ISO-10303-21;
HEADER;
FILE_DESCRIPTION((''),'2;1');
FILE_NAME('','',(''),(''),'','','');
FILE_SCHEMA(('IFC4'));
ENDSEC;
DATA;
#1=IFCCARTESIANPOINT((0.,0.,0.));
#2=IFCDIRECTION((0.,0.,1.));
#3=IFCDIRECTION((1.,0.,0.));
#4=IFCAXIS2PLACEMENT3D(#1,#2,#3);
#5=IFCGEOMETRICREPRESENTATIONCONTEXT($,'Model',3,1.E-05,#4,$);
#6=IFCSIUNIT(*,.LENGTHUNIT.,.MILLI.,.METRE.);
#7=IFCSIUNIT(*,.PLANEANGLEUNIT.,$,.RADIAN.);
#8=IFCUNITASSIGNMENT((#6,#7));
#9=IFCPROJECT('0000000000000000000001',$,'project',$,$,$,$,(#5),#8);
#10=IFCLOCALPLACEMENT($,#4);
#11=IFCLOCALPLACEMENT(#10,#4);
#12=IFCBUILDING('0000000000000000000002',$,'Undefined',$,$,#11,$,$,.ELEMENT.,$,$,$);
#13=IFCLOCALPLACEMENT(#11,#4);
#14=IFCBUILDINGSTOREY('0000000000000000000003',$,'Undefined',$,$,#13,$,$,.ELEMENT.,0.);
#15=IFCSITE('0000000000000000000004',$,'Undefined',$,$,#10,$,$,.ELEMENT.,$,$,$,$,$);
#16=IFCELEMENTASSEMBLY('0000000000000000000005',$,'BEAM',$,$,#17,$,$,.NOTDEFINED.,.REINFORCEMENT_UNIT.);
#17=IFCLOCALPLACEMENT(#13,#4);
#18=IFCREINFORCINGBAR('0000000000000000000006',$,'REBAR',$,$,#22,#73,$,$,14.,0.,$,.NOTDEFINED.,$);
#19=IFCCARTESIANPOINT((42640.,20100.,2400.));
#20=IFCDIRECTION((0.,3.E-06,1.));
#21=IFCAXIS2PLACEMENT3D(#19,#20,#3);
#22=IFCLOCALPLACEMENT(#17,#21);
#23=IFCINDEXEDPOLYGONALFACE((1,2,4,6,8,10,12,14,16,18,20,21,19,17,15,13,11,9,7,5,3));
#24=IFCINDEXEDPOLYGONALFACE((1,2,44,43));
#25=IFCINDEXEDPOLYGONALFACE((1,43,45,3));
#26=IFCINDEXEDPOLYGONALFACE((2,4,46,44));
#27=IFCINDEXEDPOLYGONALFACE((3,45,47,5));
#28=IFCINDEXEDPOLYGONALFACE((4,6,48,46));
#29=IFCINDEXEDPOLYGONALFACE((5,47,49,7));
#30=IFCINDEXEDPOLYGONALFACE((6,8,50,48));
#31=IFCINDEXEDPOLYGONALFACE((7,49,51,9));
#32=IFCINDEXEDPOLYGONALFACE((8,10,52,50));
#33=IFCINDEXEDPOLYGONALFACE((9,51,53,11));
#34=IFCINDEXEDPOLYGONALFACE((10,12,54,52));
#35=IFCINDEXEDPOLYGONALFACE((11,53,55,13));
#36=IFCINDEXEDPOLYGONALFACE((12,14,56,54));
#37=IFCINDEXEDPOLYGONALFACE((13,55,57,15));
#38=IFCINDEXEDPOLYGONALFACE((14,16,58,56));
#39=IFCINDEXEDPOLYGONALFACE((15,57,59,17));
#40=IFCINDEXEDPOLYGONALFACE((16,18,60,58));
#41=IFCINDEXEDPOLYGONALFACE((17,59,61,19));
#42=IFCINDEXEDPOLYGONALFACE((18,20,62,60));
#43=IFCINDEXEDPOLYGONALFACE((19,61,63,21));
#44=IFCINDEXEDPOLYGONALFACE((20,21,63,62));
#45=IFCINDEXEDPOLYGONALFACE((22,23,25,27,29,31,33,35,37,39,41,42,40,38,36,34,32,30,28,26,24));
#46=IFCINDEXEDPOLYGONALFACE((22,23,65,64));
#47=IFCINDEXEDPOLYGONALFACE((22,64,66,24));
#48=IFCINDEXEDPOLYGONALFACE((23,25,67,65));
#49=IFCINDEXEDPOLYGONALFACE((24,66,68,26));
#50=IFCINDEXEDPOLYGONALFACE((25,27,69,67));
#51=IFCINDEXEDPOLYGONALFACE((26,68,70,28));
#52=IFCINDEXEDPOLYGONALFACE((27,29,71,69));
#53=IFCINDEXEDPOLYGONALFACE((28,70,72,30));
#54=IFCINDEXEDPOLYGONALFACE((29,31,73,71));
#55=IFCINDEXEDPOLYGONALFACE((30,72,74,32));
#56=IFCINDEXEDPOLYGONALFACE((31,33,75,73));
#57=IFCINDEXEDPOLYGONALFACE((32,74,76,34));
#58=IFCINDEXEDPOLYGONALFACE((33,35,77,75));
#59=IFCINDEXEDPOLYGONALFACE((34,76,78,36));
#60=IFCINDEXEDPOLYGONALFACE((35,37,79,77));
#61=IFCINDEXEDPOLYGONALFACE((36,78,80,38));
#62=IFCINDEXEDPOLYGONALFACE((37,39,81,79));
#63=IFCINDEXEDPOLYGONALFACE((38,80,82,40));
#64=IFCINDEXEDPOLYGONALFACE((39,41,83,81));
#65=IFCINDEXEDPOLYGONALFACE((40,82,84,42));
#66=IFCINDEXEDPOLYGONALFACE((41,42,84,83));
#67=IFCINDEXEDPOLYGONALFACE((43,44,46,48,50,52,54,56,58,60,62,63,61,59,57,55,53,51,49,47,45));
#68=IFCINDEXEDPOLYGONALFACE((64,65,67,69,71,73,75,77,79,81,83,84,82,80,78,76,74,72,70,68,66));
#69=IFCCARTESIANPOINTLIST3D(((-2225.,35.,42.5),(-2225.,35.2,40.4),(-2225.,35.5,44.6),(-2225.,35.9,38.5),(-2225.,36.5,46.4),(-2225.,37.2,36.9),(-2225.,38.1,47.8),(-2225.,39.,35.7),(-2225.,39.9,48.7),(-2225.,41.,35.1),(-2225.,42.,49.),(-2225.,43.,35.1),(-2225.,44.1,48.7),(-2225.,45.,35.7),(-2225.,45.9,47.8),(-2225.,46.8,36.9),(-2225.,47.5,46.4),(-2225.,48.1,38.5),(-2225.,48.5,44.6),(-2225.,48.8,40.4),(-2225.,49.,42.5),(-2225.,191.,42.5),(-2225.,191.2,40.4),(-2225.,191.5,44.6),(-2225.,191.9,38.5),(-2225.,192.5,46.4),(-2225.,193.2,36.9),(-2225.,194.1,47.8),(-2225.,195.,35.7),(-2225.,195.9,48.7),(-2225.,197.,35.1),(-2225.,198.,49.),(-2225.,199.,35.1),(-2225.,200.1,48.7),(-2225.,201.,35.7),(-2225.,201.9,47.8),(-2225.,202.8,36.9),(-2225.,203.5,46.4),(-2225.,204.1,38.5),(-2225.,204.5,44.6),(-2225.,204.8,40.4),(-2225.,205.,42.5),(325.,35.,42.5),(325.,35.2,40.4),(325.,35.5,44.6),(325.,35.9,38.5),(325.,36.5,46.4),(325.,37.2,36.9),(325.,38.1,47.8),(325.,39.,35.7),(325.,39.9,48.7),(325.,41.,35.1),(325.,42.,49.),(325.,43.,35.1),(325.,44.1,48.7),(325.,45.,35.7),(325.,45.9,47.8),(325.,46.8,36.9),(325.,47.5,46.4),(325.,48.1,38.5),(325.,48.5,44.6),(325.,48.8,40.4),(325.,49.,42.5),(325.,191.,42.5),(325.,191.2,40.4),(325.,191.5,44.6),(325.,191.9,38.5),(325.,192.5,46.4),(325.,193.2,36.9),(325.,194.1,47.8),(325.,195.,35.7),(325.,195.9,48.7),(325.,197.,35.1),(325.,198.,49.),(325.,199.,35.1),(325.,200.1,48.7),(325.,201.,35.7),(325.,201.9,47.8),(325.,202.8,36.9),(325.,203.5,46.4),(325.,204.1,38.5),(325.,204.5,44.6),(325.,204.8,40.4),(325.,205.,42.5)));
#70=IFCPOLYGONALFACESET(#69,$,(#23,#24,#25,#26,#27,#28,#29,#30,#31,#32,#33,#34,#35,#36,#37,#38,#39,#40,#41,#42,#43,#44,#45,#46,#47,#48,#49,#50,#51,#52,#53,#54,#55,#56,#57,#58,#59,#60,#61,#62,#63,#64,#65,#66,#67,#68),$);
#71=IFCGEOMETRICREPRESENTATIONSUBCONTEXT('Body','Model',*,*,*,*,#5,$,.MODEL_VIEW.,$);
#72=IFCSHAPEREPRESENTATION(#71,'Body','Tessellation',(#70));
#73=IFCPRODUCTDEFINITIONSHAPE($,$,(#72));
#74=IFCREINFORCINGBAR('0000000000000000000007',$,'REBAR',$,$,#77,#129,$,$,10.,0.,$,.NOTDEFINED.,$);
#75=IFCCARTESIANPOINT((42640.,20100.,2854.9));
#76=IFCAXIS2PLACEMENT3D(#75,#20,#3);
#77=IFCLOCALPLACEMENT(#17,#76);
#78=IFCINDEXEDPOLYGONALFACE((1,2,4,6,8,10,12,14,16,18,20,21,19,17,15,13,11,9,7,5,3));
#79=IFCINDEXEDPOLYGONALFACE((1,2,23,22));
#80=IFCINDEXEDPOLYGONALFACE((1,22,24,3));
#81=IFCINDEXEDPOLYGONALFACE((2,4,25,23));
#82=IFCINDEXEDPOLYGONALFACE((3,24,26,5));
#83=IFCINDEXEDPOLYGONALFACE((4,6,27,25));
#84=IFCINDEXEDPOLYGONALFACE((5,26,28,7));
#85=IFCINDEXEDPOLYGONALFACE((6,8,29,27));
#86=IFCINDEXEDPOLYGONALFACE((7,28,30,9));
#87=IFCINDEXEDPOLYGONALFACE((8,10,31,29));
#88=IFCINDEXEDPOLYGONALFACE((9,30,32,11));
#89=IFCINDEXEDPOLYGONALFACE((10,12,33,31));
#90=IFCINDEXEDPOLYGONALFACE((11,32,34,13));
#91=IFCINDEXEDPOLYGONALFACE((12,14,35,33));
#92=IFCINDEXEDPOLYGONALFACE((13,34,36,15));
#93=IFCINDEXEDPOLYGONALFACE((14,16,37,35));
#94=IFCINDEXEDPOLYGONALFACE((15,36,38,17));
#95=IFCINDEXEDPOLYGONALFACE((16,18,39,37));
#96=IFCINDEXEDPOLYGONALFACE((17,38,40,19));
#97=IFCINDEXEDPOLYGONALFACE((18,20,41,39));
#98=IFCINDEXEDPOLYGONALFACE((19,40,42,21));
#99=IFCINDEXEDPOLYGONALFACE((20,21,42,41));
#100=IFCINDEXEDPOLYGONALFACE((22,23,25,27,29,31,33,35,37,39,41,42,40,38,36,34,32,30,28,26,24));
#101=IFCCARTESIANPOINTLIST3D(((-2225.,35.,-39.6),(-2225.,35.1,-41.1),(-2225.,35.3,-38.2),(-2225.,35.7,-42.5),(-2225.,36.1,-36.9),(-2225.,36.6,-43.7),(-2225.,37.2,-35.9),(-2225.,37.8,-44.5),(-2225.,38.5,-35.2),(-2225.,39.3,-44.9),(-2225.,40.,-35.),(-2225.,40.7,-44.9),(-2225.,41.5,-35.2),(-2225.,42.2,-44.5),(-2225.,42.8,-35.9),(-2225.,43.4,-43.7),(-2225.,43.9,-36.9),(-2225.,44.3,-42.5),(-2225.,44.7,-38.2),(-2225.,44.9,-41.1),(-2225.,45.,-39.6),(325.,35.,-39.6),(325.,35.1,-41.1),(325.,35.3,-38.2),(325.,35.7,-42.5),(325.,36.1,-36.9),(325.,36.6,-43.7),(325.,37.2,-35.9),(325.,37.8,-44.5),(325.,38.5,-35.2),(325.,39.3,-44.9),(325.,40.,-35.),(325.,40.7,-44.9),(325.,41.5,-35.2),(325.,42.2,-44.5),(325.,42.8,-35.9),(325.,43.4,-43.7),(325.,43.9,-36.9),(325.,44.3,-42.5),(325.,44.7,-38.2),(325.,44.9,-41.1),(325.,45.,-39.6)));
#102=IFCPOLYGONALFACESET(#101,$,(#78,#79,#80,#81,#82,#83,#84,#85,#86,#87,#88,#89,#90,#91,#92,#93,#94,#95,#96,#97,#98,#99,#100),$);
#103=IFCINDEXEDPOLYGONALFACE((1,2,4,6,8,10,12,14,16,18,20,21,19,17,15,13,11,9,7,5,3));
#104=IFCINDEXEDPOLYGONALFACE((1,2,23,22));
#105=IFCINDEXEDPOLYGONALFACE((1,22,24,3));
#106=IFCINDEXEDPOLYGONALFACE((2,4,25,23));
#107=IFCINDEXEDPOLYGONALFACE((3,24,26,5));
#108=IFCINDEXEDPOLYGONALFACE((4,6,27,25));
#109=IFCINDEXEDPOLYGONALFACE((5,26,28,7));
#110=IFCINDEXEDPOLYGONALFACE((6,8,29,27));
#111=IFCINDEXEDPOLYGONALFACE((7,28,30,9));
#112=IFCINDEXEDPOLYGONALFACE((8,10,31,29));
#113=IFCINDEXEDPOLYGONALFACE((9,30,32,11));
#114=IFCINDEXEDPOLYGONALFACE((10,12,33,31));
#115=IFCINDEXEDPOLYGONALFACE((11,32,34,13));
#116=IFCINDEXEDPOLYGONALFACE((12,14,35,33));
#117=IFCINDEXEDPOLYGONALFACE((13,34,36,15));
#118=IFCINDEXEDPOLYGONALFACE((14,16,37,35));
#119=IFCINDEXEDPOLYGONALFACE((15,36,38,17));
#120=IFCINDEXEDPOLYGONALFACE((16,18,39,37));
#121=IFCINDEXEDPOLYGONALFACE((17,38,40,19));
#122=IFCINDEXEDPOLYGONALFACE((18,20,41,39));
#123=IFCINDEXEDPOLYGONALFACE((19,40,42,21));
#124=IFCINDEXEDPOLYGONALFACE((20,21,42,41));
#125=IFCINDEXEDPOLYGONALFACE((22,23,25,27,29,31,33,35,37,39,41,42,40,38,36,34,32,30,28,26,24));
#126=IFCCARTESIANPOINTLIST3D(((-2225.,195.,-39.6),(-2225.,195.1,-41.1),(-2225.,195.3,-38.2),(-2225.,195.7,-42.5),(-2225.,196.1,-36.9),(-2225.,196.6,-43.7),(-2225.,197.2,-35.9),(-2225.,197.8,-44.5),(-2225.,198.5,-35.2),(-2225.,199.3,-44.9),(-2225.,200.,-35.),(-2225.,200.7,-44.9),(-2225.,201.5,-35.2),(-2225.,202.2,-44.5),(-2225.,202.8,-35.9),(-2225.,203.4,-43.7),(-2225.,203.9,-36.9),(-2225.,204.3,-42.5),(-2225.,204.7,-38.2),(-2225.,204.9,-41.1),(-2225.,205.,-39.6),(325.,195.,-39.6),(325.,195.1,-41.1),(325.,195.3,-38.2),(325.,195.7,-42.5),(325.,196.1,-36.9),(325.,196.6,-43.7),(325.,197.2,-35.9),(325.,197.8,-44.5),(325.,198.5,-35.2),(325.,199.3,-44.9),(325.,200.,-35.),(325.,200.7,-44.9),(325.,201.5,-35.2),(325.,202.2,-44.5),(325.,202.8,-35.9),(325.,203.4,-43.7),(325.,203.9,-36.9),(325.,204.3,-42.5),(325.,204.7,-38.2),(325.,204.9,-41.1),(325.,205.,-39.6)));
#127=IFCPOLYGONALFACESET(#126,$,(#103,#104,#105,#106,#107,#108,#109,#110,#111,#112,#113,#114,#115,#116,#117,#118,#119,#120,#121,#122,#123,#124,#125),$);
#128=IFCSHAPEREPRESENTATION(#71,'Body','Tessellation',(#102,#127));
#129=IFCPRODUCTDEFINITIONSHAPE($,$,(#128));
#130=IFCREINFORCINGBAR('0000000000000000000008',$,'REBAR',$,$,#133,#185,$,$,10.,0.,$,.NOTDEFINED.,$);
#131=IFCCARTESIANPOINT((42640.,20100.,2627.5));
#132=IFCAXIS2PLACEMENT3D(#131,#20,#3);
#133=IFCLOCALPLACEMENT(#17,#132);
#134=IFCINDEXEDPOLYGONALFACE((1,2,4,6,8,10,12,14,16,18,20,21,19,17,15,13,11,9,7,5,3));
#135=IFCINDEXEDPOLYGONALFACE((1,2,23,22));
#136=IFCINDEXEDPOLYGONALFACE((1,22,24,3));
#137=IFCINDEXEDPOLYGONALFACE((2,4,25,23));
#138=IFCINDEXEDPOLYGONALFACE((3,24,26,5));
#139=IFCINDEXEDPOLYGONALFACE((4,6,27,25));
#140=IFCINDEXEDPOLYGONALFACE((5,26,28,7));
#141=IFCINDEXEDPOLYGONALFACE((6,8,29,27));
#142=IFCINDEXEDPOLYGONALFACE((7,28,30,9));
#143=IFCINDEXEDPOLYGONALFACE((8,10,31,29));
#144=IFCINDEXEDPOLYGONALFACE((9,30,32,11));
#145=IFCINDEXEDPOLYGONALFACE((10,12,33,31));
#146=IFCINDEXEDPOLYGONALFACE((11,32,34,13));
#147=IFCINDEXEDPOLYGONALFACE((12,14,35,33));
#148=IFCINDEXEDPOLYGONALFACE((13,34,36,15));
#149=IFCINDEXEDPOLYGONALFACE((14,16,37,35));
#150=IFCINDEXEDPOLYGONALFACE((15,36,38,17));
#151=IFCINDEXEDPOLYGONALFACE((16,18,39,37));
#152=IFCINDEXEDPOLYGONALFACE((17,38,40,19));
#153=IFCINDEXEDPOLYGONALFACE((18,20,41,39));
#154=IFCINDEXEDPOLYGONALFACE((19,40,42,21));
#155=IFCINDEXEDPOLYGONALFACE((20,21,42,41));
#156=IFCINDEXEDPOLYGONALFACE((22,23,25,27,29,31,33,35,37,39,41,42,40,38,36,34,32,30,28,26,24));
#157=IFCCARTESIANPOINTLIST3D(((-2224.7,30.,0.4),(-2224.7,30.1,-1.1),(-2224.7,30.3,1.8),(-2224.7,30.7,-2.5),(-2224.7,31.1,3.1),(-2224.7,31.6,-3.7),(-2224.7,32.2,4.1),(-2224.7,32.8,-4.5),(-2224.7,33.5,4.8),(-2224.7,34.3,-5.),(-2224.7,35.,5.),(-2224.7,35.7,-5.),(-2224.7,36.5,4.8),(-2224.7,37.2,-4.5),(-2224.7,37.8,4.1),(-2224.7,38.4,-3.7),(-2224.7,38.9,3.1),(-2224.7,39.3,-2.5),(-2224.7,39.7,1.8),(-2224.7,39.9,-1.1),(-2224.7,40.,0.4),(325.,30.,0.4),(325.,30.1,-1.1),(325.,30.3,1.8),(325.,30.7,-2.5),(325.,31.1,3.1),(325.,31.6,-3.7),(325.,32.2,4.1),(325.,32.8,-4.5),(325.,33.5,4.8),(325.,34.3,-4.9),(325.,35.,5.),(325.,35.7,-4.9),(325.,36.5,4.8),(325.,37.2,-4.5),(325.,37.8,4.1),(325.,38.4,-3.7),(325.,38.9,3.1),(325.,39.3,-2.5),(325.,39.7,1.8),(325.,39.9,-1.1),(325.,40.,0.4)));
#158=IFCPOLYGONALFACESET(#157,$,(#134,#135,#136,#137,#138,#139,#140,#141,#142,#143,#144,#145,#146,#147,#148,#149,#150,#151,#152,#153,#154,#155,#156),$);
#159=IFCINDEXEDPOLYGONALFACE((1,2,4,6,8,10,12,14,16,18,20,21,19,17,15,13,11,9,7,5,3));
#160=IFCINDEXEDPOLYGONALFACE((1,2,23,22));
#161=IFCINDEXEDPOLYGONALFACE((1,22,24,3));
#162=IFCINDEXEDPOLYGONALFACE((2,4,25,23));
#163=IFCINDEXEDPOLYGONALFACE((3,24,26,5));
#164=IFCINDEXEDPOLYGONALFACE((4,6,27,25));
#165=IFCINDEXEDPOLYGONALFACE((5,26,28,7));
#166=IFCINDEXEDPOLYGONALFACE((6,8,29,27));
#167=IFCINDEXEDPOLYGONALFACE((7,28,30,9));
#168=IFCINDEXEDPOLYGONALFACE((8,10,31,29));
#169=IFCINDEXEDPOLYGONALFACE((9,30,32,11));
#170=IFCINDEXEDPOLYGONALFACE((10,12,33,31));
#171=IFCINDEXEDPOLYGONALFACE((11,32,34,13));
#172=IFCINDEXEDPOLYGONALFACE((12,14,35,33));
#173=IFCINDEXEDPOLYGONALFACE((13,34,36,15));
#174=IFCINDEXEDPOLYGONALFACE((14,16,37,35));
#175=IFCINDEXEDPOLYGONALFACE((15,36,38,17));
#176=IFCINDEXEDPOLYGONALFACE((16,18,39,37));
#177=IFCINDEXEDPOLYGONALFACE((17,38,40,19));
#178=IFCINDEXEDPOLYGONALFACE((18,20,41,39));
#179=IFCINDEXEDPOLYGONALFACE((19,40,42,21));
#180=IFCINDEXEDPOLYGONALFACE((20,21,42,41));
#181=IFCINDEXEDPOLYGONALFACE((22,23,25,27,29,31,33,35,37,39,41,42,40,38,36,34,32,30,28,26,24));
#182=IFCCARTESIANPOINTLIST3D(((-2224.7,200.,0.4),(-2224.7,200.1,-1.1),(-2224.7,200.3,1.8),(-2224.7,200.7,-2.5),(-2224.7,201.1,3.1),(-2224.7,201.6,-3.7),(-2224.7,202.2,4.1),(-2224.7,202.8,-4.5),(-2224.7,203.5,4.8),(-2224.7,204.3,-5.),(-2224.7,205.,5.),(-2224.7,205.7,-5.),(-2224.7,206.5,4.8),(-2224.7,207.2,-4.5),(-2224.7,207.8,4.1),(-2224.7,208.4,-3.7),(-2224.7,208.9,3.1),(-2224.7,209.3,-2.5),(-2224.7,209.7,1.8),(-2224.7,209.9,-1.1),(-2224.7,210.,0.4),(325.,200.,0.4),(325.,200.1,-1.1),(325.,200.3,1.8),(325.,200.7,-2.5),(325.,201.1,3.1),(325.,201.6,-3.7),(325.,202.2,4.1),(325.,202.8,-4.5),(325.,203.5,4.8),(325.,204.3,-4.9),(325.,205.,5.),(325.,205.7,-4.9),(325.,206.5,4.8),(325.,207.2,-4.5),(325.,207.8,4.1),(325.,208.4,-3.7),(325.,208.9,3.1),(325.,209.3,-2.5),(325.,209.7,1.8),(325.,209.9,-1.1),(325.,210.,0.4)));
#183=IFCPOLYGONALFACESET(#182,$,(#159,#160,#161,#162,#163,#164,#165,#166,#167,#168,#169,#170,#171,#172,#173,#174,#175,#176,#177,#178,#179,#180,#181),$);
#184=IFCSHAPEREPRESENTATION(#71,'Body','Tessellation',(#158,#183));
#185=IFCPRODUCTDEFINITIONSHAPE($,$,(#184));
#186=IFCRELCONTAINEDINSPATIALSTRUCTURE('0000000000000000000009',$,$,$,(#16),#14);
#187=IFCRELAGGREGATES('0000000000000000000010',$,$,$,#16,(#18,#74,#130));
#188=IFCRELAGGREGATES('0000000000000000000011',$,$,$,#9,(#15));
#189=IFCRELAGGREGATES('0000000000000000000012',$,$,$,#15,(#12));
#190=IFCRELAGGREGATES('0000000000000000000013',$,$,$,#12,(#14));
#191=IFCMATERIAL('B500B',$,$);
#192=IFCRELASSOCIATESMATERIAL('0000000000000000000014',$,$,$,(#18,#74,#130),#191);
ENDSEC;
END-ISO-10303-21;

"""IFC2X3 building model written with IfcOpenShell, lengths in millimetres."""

from ifc_helpers import new_model, entity, si_unit, frame, origin_with_axes, place, context, subcontext, project, spatial, source, transform, mapped, material, element, aggregate, save


model = new_model("IFC2X3")

# Units and contexts
model_context = context("Model", 3, precision=1e-05, world=origin_with_axes())
body_context = subcontext(model_context, "Body", "Model", "MODEL_VIEW")
ifc_project = project(units=[si_unit("LENGTHUNIT", "METRE", prefix="MILLI"), si_unit("PLANEANGLEUNIT", "RADIAN")], contexts=[model_context])

# Site, building, storey
site_placement = place(None, origin_with_axes())
site = spatial("IfcSite", under=ifc_project, at=site_placement, Name="Undefined", CompositionType="ELEMENT")
building_placement = place(site_placement, origin_with_axes())
building = spatial("IfcBuilding", under=site, at=building_placement, Name="Undefined", CompositionType="ELEMENT")
storey_placement = place(building_placement, origin_with_axes())
storey = spatial("IfcBuildingStorey", under=building, at=storey_placement, Name="Undefined", CompositionType="ELEMENT", Elevation=0.0)

# Element assembly
assembly_1_placement = place(storey_placement, origin_with_axes())
assembly_1 = element("IfcElementAssembly", 1, at=assembly_1_placement, inside=storey, Name="BEAM", AssemblyPlace="NOTDEFINED", PredefinedType="REINFORCEMENT_UNIT")

# Shared definitions
ifc_material_1 = material(Name="B500B")

# Reinforcing bars
shared_shape_1 = source(origin_with_axes(), body_context, "Body", "AdvancedSweptSolid", [
    entity("IfcSweptDiskSolid", entity("IfcTrimmedCurve", entity("IfcLine", entity("IfcCartesianPoint", [0.0, 0.0, 0.0]), entity("IfcVector", entity("IfcDirection", [1.0, 0.0, 0.0]), 1.0)), [entity("IfcParameterValue", 0.0)], [entity("IfcParameterValue", 2549.999615)], True, "PARAMETER"), 7.0, None, 0.0, 2550.0),
])
shared_shape_2 = source(origin_with_axes(), body_context, "Body", "AdvancedSweptSolid", [
    entity("IfcSweptDiskSolid", entity("IfcTrimmedCurve", entity("IfcLine", entity("IfcCartesianPoint", [0.0, 0.0, 0.0]), entity("IfcVector", entity("IfcDirection", [1.0, 0.0, 0.0]), 1.0)), [entity("IfcParameterValue", 0.0)], [entity("IfcParameterValue", 2549.999615)], True, "PARAMETER"), 7.0, None, 0.0, 2550.0),
])
reinforcing_bar_1_placement = place(assembly_1_placement, frame((42640.0, 20100.0, 2400.0), z_axis=(0.0, 0.000003, 1.0), x_axis=(1.0, 0.0, 0.0)))
reinforcing_bar_1 = element("IfcReinforcingBar", 2, at=reinforcing_bar_1_placement, material=ifc_material_1, Name="REBAR", BarRole="NOTDEFINED", CrossSectionArea=0.0, NominalDiameter=14.0, context=body_context, shape_type="MappedRepresentation", body=[
    mapped(shared_shape_1, transform((-2225.0, 42.0, 42.0))),
    mapped(shared_shape_2, transform((-2225.0, 198.0, 42.0))),
])
shared_shape_3 = source(origin_with_axes(), body_context, "Body", "AdvancedSweptSolid", [
    entity("IfcSweptDiskSolid", entity("IfcTrimmedCurve", entity("IfcLine", entity("IfcCartesianPoint", [0.0, 0.0, 0.0]), entity("IfcVector", entity("IfcDirection", [1.0, 0.0, 0.0]), 1.0)), [entity("IfcParameterValue", 0.0)], [entity("IfcParameterValue", 2549.999615)], True, "PARAMETER"), 5.0, None, 0.0, 2550.0),
])
shared_shape_4 = source(origin_with_axes(), body_context, "Body", "AdvancedSweptSolid", [
    entity("IfcSweptDiskSolid", entity("IfcTrimmedCurve", entity("IfcLine", entity("IfcCartesianPoint", [0.0, 0.0, 0.0]), entity("IfcVector", entity("IfcDirection", [1.0, 0.0, 0.0]), 1.0)), [entity("IfcParameterValue", 0.0)], [entity("IfcParameterValue", 2549.999615)], True, "PARAMETER"), 5.0, None, 0.0, 2550.0),
])
reinforcing_bar_2_placement = place(assembly_1_placement, frame((42640.0, 20100.0, 2854.9), z_axis=(0.0, 0.000003, 1.0), x_axis=(1.0, 0.0, 0.0)))
reinforcing_bar_2 = element("IfcReinforcingBar", 3, at=reinforcing_bar_2_placement, material=ifc_material_1, Name="REBAR", BarRole="NOTDEFINED", CrossSectionArea=0.0, NominalDiameter=10.0, context=body_context, shape_type="MappedRepresentation", body=[
    mapped(shared_shape_3, transform((-2225.0, 40.0, -40.0))),
    mapped(shared_shape_4, transform((-2225.0, 200.0, -40.0))),
])
shared_shape_5 = source(origin_with_axes(), body_context, "Body", "AdvancedSweptSolid", [
    entity("IfcSweptDiskSolid", entity("IfcTrimmedCurve", entity("IfcLine", entity("IfcCartesianPoint", [0.0, 0.0, 0.0]), entity("IfcVector", entity("IfcDirection", [1.0, 0.0, 0.000004]), 1.0)), [entity("IfcParameterValue", 0.0)], [entity("IfcParameterValue", 2549.779615)], True, "PARAMETER"), 5.0, None, 0.0, 2549.8),
])
shared_shape_6 = source(origin_with_axes(), body_context, "Body", "AdvancedSweptSolid", [
    entity("IfcSweptDiskSolid", entity("IfcTrimmedCurve", entity("IfcLine", entity("IfcCartesianPoint", [0.0, 0.0, 0.0]), entity("IfcVector", entity("IfcDirection", [1.0, 0.0, 0.000004]), 1.0)), [entity("IfcParameterValue", 0.0)], [entity("IfcParameterValue", 2549.779615)], True, "PARAMETER"), 5.0, None, 0.0, 2549.8),
])
reinforcing_bar_3_placement = place(assembly_1_placement, frame((42640.0, 20100.0, 2627.5), z_axis=(0.0, 0.000003, 1.0), x_axis=(1.0, 0.0, 0.0)))
reinforcing_bar_3 = element("IfcReinforcingBar", 4, at=reinforcing_bar_3_placement, material=ifc_material_1, Name="REBAR", BarRole="NOTDEFINED", CrossSectionArea=0.0, NominalDiameter=10.0, context=body_context, shape_type="MappedRepresentation", body=[
    mapped(shared_shape_5, transform((-2224.7, 35.0, 0.0))),
    mapped(shared_shape_6, transform((-2224.7, 205.0, 0.0))),
])
aggregate(assembly_1, [reinforcing_bar_1, reinforcing_bar_2, reinforcing_bar_3])

save(model, "model.ifc")
